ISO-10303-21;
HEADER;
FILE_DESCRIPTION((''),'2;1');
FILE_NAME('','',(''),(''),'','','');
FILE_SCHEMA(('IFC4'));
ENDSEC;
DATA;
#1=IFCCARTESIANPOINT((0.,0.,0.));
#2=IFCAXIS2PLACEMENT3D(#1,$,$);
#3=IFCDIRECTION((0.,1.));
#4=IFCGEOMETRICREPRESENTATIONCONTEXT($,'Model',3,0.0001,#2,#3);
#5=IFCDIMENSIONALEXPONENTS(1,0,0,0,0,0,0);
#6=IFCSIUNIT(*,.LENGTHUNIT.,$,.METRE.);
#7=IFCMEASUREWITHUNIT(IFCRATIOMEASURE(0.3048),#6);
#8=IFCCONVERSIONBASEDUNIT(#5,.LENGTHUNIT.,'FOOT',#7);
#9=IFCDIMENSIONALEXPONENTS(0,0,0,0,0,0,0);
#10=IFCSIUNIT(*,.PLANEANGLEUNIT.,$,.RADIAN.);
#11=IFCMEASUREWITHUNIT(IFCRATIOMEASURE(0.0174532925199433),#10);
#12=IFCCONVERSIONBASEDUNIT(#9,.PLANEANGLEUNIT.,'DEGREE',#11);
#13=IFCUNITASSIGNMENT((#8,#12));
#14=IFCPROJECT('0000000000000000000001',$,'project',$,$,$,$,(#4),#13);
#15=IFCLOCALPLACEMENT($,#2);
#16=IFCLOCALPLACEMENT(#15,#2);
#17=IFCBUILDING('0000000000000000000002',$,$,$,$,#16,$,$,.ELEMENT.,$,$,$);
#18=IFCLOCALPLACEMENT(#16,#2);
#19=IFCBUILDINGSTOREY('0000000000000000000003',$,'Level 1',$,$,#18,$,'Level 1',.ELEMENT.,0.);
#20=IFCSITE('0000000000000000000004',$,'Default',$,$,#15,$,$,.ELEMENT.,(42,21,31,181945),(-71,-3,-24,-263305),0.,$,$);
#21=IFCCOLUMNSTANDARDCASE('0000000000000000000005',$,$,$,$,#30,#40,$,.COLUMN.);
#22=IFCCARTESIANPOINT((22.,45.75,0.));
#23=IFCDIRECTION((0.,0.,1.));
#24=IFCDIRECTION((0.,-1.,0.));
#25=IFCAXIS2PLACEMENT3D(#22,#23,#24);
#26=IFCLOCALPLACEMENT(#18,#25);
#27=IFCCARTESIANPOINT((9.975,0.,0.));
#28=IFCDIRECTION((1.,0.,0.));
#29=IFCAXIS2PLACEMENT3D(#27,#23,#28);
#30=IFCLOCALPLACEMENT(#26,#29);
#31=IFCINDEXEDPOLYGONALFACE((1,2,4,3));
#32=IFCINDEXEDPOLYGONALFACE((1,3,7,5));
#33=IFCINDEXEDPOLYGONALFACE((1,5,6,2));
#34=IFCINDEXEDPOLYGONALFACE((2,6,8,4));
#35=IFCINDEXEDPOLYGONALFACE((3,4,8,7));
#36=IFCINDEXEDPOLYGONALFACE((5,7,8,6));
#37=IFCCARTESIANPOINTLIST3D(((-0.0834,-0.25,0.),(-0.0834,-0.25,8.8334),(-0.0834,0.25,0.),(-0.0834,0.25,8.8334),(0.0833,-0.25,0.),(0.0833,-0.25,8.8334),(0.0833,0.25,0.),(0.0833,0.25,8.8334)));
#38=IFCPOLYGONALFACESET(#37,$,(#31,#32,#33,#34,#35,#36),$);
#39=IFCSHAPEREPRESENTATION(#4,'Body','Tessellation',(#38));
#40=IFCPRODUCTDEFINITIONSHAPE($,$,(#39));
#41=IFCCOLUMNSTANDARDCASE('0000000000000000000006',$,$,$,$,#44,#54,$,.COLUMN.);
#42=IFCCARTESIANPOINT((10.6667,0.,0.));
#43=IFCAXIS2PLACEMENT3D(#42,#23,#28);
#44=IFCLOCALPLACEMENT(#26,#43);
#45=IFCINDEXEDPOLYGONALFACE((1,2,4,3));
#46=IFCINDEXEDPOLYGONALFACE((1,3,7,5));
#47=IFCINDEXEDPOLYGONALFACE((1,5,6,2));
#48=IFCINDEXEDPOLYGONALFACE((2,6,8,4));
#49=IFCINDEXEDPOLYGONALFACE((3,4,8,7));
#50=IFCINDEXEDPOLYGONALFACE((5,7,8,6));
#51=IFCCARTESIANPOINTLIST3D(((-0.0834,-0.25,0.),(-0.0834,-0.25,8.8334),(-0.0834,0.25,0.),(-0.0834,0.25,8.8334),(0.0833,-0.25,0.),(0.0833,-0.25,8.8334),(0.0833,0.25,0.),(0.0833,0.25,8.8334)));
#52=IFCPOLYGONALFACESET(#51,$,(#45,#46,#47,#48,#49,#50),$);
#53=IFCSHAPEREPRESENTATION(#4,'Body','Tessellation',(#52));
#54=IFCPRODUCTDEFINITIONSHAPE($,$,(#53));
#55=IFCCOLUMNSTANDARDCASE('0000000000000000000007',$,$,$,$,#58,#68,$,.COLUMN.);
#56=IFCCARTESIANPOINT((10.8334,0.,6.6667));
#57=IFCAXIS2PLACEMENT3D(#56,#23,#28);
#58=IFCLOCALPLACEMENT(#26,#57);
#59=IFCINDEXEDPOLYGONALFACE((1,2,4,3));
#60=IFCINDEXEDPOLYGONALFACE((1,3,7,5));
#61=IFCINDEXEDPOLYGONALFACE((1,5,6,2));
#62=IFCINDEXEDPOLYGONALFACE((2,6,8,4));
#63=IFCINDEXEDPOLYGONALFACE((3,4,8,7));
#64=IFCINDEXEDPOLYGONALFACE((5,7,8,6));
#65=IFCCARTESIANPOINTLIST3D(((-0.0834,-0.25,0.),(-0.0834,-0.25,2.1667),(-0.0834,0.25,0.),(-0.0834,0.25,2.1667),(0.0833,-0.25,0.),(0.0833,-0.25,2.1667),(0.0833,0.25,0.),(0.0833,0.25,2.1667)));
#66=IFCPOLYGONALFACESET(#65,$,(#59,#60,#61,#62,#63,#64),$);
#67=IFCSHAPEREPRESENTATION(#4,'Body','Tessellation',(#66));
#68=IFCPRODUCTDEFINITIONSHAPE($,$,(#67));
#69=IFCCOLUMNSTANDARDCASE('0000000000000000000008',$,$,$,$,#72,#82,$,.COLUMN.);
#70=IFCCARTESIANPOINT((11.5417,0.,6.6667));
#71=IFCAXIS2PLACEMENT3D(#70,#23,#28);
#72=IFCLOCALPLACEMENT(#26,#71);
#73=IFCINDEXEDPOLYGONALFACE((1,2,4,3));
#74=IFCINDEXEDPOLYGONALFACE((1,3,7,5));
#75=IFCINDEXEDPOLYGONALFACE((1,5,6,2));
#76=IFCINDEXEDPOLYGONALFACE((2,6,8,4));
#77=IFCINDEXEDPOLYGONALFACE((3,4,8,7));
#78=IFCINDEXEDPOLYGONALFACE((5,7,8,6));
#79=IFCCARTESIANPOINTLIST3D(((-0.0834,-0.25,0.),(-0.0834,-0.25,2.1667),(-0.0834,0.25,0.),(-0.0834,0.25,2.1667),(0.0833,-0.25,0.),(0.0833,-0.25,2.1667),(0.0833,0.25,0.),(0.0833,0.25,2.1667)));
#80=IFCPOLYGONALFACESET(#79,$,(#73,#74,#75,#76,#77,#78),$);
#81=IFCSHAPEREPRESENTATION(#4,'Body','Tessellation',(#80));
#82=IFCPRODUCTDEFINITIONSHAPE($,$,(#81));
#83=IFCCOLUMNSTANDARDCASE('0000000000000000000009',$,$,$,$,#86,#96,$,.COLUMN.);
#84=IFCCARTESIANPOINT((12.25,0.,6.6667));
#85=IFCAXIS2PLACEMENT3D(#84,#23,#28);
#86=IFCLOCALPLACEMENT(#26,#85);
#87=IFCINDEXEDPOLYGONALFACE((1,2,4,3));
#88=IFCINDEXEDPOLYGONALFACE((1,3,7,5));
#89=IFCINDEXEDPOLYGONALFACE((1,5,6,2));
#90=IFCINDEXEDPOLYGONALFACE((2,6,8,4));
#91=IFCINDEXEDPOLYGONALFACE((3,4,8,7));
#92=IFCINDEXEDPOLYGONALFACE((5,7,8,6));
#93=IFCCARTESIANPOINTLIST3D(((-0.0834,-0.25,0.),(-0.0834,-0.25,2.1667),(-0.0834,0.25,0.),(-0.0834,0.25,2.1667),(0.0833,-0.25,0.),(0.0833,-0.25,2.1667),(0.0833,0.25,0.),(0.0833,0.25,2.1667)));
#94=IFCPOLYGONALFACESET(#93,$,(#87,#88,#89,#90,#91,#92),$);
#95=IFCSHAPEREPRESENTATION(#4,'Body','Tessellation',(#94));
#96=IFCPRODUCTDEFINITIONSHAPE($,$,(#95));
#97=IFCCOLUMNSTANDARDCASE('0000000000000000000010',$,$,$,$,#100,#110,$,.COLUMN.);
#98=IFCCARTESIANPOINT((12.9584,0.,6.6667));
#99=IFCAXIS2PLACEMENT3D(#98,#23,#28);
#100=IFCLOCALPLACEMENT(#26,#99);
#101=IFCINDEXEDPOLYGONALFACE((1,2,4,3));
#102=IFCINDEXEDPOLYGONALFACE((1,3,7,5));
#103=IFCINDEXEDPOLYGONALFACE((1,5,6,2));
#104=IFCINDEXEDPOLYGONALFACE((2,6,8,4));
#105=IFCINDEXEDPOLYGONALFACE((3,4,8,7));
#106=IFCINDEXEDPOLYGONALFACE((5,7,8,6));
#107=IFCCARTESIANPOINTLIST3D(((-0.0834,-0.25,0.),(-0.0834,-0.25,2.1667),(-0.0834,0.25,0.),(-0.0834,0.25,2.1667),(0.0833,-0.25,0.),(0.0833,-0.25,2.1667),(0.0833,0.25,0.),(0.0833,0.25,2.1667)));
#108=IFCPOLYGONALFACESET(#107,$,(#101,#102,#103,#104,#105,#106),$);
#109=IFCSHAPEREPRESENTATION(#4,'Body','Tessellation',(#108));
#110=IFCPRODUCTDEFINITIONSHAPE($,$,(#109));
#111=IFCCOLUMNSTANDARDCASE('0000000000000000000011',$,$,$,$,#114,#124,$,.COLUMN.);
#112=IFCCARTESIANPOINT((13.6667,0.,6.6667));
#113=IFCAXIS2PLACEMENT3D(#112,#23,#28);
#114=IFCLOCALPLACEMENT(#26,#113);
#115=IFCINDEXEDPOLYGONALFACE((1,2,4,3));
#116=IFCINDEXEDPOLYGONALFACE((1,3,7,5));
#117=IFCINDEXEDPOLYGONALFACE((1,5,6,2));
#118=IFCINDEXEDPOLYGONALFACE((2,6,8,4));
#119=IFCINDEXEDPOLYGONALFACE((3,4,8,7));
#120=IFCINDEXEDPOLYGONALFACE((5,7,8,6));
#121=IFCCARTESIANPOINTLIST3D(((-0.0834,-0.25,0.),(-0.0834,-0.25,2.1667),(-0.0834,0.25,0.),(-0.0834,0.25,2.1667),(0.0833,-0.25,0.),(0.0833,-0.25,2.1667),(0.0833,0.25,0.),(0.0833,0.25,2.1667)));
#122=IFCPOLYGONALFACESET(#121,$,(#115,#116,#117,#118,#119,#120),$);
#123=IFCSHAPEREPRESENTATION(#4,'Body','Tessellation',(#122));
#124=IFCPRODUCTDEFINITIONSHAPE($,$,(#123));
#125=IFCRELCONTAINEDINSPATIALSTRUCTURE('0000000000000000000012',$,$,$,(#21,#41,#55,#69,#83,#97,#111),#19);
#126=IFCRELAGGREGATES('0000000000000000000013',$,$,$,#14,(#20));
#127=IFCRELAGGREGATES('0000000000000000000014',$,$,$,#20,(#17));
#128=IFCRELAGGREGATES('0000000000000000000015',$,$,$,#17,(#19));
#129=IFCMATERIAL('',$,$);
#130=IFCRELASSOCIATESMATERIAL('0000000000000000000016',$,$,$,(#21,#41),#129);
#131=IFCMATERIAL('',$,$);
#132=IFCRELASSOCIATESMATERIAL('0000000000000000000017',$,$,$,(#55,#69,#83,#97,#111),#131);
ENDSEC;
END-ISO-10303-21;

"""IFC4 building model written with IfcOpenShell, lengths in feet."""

from ifc_helpers import new_model, entity, si_unit, converted_unit, direction, frame, origin, place, context, project, spatial, rectangle, extrude, material, element, save


model = new_model("IFC4")

# Units and contexts
model_context = context("Model", 3, precision=0.0001, world=origin(), true_north=direction((0.0, 1.0)))
ifc_project = project(units=[converted_unit("LENGTHUNIT", "FOOT", entity("IfcRatioMeasure", 0.3048), si_unit("LENGTHUNIT", "METRE"), dimensions=[1, 0, 0, 0, 0, 0, 0]), converted_unit("PLANEANGLEUNIT", "DEGREE", entity("IfcRatioMeasure", 0.0174532925199433), si_unit("PLANEANGLEUNIT", "RADIAN"), dimensions=[0, 0, 0, 0, 0, 0, 0])], contexts=[model_context])

# Site, building, storey
site_placement = place(None, origin())
site = spatial("IfcSite", under=ifc_project, at=site_placement, Name="Default", CompositionType="ELEMENT", RefLatitude=(42, 21, 31, 181945), RefLongitude=(-71, -3, -24, -263305), RefElevation=0.0)
building_placement = place(site_placement, origin())
building = spatial("IfcBuilding", under=site, at=building_placement, CompositionType="ELEMENT")
storey_placement = place(building_placement, origin())
storey = spatial("IfcBuildingStorey", under=building, at=storey_placement, Name="Level 1", LongName="Level 1", CompositionType="ELEMENT", Elevation=0.0)

# Columns
placement_1 = place(storey_placement, frame((22.0, 45.75, 0.0), z_axis=(0.0, 0.0, 1.0), x_axis=(0.0, -1.0, 0.0)))
ifc_material_1 = material(Name="")
for number, where, z_axis, x_axis in (
    (1, (9.975, 0.0, 0.0), (0.0, 0.0, 1.0), (1.0, 0.0, 0.0)),
    (2, (10.6667, 0.0, 0.0), (0.0, 0.0, 1.0), (1.0, 0.0, 0.0)),
):
    element("IfcColumnStandardCase", number, at=place(placement_1, frame(where, z_axis=z_axis, x_axis=x_axis)), inside=storey, material=ifc_material_1, PredefinedType="COLUMN", context=model_context, shape_type="SweptSolid", body=[
        extrude(rectangle(XDim=0.1667, YDim=0.5), origin(), (0.0, 0.0, 1.0), 8.8334),
    ])
ifc_material_2 = material(Name="")
for number, where, z_axis, x_axis in (
    (3, (10.8334, 0.0, 6.6667), (0.0, 0.0, 1.0), (1.0, 0.0, 0.0)),
    (4, (11.5417, 0.0, 6.6667), (0.0, 0.0, 1.0), (1.0, 0.0, 0.0)),
    (5, (12.25, 0.0, 6.6667), (0.0, 0.0, 1.0), (1.0, 0.0, 0.0)),
    (6, (12.9584, 0.0, 6.6667), (0.0, 0.0, 1.0), (1.0, 0.0, 0.0)),
    (7, (13.6667, 0.0, 6.6667), (0.0, 0.0, 1.0), (1.0, 0.0, 0.0)),
):
    element("IfcColumnStandardCase", number, at=place(placement_1, frame(where, z_axis=z_axis, x_axis=x_axis)), inside=storey, material=ifc_material_2, PredefinedType="COLUMN", context=model_context, shape_type="SweptSolid", body=[
        extrude(rectangle(XDim=0.1667, YDim=0.5), origin(), (0.0, 0.0, 1.0), 2.1667),
    ])

save(model, "model.ifc")
